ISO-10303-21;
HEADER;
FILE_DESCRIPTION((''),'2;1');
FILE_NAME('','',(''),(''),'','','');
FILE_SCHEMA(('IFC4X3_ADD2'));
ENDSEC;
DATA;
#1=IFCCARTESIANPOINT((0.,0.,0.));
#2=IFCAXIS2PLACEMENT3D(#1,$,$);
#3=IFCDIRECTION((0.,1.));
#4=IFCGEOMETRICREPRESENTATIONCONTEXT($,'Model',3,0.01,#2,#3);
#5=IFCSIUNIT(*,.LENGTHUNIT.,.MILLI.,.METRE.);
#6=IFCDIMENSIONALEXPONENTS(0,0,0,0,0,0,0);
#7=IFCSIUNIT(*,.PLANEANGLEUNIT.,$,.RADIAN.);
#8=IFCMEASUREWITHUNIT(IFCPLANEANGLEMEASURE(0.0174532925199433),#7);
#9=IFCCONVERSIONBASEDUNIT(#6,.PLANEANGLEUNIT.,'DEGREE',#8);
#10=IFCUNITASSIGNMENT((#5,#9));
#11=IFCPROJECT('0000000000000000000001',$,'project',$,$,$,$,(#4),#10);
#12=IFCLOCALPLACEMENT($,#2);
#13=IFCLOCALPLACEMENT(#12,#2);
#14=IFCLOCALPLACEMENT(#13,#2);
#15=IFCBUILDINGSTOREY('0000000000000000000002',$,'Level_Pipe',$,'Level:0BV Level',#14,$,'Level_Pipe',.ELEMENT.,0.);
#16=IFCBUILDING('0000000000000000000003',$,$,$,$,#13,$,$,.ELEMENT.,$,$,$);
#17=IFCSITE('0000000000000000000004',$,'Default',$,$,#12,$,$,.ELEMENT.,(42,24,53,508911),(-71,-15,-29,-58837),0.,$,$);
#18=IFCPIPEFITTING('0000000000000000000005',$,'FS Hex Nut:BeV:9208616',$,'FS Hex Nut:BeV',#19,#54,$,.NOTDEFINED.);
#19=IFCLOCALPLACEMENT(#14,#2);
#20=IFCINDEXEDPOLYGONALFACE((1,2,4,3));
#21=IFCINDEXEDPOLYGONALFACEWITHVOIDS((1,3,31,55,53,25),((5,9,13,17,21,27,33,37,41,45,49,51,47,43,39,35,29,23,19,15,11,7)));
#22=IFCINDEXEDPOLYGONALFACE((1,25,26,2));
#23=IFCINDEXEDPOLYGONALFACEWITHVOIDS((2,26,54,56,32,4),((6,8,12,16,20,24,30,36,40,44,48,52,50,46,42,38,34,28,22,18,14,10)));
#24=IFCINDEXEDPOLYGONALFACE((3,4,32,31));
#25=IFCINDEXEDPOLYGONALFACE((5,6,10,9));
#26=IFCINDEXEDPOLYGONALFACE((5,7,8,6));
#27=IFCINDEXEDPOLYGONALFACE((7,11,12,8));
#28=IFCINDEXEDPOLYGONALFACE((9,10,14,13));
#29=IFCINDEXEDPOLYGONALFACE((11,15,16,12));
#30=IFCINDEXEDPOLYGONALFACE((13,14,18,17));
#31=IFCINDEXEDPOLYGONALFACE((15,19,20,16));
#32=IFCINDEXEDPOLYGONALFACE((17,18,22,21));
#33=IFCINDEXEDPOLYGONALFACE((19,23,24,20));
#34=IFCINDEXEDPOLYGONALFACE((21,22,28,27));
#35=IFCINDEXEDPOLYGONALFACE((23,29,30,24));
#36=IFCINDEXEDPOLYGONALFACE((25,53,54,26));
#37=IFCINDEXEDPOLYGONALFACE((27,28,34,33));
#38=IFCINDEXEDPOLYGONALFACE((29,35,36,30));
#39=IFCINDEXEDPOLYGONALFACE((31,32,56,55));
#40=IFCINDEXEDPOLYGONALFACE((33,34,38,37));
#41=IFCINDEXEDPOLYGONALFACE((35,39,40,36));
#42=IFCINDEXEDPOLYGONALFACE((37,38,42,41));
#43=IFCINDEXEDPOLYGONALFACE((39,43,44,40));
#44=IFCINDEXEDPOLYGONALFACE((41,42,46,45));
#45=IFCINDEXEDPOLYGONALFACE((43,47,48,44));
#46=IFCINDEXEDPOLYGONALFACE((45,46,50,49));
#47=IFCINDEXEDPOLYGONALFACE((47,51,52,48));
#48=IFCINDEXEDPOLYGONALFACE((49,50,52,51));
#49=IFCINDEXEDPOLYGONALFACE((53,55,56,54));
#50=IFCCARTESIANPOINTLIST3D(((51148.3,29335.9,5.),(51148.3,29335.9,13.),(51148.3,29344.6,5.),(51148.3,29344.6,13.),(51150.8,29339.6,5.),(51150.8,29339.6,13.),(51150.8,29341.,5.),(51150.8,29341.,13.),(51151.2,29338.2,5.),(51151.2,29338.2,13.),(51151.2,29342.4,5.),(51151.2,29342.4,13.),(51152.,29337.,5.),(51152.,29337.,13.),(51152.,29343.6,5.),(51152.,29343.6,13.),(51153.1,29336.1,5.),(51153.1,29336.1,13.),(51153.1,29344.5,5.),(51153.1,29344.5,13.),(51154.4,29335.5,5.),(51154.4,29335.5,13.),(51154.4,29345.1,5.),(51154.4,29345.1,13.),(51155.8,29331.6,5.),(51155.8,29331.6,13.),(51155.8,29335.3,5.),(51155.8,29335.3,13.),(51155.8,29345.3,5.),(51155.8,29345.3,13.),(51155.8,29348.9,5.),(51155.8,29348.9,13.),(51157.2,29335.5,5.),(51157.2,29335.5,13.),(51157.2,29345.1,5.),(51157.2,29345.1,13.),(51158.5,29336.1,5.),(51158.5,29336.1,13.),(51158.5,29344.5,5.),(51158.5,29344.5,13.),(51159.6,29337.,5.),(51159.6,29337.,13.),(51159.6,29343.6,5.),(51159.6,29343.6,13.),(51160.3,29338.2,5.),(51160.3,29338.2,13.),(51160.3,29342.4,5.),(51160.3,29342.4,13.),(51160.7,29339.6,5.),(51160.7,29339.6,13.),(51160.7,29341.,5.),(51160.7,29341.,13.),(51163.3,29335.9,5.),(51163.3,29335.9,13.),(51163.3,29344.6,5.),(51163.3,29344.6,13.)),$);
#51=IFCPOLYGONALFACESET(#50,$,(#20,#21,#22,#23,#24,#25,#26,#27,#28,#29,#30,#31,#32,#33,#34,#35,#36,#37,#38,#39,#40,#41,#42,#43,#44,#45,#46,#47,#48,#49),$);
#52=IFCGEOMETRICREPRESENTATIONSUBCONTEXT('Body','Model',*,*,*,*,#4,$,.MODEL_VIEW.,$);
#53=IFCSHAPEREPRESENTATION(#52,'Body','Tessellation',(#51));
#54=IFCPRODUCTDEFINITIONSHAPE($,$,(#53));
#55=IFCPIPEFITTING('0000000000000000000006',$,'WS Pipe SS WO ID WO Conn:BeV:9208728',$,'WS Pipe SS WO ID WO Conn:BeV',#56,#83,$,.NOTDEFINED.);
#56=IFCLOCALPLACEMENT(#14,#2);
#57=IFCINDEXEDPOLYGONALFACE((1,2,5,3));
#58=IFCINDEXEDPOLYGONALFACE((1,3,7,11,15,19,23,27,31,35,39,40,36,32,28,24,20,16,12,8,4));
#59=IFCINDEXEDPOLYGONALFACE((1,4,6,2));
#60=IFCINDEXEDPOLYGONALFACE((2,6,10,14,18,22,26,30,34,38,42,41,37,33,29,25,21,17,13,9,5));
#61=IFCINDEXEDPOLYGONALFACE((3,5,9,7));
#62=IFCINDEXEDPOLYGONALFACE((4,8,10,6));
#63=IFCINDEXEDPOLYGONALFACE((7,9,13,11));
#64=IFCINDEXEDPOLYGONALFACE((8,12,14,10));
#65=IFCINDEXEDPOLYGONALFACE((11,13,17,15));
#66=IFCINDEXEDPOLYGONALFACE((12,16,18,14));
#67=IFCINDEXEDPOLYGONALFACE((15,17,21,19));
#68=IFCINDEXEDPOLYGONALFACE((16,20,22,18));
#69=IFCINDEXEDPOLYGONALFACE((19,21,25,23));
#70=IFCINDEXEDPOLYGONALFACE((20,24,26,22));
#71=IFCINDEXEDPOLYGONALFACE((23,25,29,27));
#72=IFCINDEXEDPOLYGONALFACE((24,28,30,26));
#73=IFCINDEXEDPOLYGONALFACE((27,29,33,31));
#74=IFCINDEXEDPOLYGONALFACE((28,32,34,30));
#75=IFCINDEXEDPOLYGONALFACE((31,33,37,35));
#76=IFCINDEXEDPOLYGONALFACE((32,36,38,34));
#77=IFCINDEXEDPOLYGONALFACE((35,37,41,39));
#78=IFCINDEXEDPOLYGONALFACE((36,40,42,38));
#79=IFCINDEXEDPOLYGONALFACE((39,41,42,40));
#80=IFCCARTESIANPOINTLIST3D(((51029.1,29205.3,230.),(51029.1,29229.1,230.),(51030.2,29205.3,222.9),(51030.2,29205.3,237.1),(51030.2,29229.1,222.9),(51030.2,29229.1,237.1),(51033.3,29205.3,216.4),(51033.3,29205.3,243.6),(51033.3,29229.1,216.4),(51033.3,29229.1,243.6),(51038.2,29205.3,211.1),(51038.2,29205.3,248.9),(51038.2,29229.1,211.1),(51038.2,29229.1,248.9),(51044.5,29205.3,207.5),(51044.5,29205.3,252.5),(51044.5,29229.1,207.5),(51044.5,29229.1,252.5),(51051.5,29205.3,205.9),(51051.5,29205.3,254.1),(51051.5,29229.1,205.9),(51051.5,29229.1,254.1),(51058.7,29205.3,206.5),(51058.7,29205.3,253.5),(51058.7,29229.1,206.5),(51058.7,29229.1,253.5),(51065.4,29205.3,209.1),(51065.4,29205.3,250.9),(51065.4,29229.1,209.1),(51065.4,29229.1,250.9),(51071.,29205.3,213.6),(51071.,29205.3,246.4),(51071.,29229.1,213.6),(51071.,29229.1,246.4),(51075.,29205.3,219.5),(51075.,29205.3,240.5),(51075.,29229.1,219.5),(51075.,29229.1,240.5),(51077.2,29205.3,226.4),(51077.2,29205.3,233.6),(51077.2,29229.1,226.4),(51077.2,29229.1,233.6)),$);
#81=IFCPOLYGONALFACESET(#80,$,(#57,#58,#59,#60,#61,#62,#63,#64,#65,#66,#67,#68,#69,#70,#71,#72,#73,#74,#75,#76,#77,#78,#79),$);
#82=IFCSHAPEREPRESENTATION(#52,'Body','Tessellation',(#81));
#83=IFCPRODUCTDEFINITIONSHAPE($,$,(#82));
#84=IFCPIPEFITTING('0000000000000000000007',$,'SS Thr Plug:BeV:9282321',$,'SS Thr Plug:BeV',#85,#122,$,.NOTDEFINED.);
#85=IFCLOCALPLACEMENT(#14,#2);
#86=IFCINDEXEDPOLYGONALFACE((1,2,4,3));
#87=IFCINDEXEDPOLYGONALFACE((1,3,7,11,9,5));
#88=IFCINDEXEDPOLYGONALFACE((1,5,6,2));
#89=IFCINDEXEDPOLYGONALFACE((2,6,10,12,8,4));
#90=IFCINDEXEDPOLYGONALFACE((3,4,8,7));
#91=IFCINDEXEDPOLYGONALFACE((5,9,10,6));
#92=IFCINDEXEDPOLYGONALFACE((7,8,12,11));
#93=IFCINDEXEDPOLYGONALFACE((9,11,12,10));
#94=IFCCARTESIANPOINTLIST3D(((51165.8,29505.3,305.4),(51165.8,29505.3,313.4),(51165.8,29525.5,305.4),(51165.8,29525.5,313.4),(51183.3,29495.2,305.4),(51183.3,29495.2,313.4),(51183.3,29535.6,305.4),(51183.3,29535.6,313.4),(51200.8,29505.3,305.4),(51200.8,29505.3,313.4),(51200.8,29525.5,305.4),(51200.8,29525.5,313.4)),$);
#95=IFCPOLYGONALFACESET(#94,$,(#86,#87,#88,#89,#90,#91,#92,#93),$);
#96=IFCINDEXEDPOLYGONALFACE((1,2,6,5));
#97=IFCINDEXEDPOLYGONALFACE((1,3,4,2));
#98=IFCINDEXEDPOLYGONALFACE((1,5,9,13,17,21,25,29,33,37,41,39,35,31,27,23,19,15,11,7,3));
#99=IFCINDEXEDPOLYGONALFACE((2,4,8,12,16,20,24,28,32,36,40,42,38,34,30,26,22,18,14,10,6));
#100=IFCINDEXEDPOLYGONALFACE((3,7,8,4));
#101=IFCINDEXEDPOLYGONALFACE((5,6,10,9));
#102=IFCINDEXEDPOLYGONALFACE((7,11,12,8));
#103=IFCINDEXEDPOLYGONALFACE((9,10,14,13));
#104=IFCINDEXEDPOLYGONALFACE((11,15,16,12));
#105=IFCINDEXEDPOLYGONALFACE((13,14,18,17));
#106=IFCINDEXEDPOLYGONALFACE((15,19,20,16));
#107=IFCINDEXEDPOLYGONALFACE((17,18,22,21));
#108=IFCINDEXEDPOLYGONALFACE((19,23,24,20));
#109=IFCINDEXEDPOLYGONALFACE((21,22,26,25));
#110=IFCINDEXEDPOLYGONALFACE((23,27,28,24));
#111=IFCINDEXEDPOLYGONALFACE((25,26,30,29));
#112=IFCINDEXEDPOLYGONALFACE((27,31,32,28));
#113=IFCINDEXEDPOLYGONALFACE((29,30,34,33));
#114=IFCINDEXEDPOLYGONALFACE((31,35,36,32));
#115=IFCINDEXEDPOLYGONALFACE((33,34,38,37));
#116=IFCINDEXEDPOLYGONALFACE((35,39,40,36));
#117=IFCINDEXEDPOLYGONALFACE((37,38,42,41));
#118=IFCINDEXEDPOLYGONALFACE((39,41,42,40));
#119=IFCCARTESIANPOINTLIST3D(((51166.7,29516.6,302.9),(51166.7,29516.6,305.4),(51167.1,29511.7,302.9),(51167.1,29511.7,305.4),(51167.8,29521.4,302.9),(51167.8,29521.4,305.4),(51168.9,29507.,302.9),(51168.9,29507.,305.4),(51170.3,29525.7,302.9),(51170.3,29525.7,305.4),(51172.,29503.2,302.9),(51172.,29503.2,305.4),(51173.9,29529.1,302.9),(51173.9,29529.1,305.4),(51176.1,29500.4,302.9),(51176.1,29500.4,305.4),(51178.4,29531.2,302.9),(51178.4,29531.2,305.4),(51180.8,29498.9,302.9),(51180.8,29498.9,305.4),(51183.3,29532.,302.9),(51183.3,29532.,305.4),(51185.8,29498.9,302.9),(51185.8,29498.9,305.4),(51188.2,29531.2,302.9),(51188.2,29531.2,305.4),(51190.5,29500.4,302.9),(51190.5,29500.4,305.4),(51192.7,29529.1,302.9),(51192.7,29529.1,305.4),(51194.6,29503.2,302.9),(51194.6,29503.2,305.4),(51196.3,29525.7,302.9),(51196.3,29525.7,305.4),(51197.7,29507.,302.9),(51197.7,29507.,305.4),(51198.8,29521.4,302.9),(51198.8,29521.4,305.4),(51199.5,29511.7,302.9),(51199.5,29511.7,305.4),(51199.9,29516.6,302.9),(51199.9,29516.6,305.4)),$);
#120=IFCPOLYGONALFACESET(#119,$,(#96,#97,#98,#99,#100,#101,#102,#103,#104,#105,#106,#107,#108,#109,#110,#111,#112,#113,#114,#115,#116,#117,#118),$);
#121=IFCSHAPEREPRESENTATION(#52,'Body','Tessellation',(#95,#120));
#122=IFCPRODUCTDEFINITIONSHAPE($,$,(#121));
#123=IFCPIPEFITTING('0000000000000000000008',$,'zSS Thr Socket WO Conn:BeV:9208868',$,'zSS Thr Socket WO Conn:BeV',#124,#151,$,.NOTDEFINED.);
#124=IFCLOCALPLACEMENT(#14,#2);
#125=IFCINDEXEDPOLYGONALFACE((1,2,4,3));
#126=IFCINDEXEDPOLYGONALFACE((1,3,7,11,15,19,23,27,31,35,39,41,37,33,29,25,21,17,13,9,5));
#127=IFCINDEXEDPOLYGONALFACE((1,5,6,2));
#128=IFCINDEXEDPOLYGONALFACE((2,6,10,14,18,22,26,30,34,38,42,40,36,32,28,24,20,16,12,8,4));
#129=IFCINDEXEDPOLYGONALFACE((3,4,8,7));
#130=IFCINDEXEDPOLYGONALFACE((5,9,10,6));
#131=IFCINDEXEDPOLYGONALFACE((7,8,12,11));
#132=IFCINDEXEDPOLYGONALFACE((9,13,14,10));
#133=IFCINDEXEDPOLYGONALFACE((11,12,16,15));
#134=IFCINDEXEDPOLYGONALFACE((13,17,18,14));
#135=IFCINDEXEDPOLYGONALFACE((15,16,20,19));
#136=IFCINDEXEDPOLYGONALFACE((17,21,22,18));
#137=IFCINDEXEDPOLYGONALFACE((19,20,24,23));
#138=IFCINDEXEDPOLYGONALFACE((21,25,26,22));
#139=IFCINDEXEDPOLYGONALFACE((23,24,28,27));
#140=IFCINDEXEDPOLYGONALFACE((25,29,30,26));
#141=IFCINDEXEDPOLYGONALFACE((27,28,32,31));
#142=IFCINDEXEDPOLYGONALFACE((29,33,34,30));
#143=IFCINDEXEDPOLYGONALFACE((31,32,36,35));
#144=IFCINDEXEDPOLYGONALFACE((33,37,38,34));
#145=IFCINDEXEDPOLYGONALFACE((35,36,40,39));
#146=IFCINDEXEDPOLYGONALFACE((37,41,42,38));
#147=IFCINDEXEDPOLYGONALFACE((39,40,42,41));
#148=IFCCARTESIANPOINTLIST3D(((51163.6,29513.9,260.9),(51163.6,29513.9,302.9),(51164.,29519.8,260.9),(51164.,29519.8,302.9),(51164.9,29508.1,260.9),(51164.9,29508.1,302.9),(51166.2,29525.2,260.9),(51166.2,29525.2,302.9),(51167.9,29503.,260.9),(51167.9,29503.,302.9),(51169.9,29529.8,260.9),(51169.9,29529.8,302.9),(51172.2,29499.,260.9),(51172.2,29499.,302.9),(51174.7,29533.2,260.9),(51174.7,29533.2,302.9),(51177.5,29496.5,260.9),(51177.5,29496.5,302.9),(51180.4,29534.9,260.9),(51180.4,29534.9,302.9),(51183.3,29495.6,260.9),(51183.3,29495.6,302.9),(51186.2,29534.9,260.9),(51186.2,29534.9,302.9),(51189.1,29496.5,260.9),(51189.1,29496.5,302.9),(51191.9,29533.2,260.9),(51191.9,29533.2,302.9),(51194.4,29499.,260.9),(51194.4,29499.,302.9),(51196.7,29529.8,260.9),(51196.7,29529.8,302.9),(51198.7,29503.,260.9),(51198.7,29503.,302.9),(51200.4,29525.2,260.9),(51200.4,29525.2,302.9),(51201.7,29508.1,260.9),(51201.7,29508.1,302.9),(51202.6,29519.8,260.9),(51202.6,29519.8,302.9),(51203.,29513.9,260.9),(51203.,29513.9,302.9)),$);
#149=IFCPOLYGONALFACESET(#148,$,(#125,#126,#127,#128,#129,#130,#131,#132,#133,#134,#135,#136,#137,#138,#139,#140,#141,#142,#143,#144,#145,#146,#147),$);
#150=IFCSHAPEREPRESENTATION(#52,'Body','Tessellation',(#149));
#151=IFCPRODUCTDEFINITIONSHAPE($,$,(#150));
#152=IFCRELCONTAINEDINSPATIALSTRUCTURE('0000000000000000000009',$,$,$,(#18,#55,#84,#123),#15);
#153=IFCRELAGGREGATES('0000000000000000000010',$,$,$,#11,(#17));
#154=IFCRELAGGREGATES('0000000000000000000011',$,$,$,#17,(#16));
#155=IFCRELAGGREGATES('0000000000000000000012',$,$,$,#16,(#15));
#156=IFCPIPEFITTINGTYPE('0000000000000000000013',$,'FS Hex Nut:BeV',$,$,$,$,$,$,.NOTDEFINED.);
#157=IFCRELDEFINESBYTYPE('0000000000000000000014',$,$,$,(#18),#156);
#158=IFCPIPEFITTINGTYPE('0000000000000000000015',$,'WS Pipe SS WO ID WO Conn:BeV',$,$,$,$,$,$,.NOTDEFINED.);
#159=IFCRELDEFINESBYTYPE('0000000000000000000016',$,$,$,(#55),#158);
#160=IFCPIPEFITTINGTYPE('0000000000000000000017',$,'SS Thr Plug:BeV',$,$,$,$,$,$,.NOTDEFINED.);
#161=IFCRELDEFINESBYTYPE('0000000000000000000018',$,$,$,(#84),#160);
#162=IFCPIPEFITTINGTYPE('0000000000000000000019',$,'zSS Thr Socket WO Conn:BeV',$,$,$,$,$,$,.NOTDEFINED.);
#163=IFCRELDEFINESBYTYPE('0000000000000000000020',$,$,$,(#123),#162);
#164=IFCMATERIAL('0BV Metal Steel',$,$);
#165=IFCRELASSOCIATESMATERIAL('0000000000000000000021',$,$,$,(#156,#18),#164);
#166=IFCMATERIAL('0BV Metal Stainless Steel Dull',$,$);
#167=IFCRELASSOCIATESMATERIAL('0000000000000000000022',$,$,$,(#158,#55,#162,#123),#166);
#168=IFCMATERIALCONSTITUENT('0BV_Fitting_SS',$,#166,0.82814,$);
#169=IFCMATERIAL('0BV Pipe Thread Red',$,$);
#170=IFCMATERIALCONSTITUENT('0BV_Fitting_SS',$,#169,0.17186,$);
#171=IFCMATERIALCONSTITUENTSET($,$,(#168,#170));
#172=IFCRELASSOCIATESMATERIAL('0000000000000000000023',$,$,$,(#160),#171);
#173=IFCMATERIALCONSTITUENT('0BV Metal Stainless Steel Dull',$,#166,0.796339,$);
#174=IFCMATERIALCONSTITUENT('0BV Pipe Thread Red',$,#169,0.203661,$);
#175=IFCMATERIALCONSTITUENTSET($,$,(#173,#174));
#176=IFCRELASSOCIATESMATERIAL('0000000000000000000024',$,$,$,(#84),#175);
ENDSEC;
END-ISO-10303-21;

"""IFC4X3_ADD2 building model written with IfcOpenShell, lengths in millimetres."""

from ifc_helpers import new_model, entity, si_unit, converted_unit, direction, frame, frame_2d, origin, place, context, subcontext, project, spatial, polyline, circle_curve, parameter, trimmed, segment, composite_curve, circle, outline, extrude, source, transform, mapped, material, constituent, constituent_set, type_object, type_shapes, element, save


model = new_model("IFC4X3_ADD2")

# Units and contexts
model_context = context("Model", 3, precision=0.01, world=origin(), true_north=direction((0.0, 1.0)))
body_context = subcontext(model_context, "Body", "Model", "MODEL_VIEW")
ifc_project = project(units=[si_unit("LENGTHUNIT", "METRE", prefix="MILLI"), converted_unit("PLANEANGLEUNIT", "DEGREE", entity("IfcPlaneAngleMeasure", 0.0174532925199433), si_unit("PLANEANGLEUNIT", "RADIAN"), dimensions=[0, 0, 0, 0, 0, 0, 0])], contexts=[model_context])

# Site, building, storey
site_placement = place(None, origin())
site = spatial("IfcSite", under=ifc_project, at=site_placement, Name="Default", CompositionType="ELEMENT", RefLatitude=(42, 24, 53, 508911), RefLongitude=(-71, -15, -29, -58837), RefElevation=0.0)
building_placement = place(site_placement, origin())
building = spatial("IfcBuilding", under=site, at=building_placement, CompositionType="ELEMENT")
storey_placement = place(building_placement, origin())
storey = spatial("IfcBuildingStorey", under=building, at=storey_placement, Name="Level_Pipe", ObjectType="Level:0BV Level", LongName="Level_Pipe", CompositionType="ELEMENT", Elevation=0.0)

# Pipe fittings
ifc_material_1 = material(Name="0BV Metal Stainless Steel Dull")
ifc_material_2 = material(Name="0BV Metal Steel")
ifc_material_3 = material(Name="0BV Pipe Thread Red")
pipe_fitting_type_1 = type_object("IfcPipeFittingType", Name="FS Hex Nut:BeV", PredefinedType="NOTDEFINED", material=ifc_material_2)
shared_shape_1 = source(origin(), body_context, "Body", "SweptSolid", [
    extrude(outline(polyline([(-4.3, -7.5), (4.3, -7.5), (8.7, 0.0), (4.3, 7.5), (-4.3, 7.5), (-8.7, 0.0), (-4.3, -7.5)]), holes=[composite_curve([segment(trimmed(circle_curve(frame_2d((0.0, 0.0), x_axis=(-0.5, 0.866025)), 5.0), [parameter(0.0)], [parameter(180.0)], True, "PARAMETER"), False, "CONTINUOUS"), segment(trimmed(circle_curve(frame_2d((0.0, 0.0), x_axis=(-0.5, 0.866025)), 5.0), [parameter(180.0)], [parameter(360.0)], True, "PARAMETER"), False, "CONTINUOUS")], self_intersect=False)]), frame((0.0, 8.7, 7.5), z_axis=(1.0, 0.0, 0.0), x_axis=(0.0, -0.5, -0.866025)), (0.0, 0.0, 1.0), 8.0),
])
type_shapes(pipe_fitting_type_1, [shared_shape_1])
pipe_fitting_1_placement = place(storey_placement, frame((51148.3, 29331.6, 13.0), z_axis=(1.0, 0.0, 0.0), x_axis=(0.0, 0.0, -1.0)))
element("IfcPipeFitting", 1, at=pipe_fitting_1_placement, inside=storey, type_object=pipe_fitting_type_1, material=ifc_material_2, Name="FS Hex Nut:BeV:9208616", ObjectType="FS Hex Nut:BeV", PredefinedType="NOTDEFINED", context=body_context, shape_type="MappedRepresentation", body=[
    mapped(shared_shape_1, transform((0.0, 0.0, 0.0), scale=1.0)),
])
pipe_fitting_type_2 = type_object("IfcPipeFittingType", Name="WS Pipe SS WO ID WO Conn:BeV", PredefinedType="NOTDEFINED", material=ifc_material_1)
shared_shape_2 = source(origin(), body_context, "Body", "SweptSolid", [
    extrude(circle(Radius=24.1, at=frame_2d((0.0, 0.0), x_axis=(1.0, 0.0))), frame((-11.9, 0.0, 0.0), z_axis=(1.0, 0.0, 0.0), x_axis=(0.0, 1.0, 0.0)), (0.0, 0.0, 1.0), 23.8),
])
type_shapes(pipe_fitting_type_2, [shared_shape_2])
pipe_fitting_2_placement = place(storey_placement, frame((51053.3, 29217.2, 230.0), z_axis=(0.0, 0.0, 1.0), x_axis=(0.0, 1.0, 0.0)))
element("IfcPipeFitting", 2, at=pipe_fitting_2_placement, inside=storey, type_object=pipe_fitting_type_2, material=ifc_material_1, Name="WS Pipe SS WO ID WO Conn:BeV:9208728", ObjectType="WS Pipe SS WO ID WO Conn:BeV", PredefinedType="NOTDEFINED", context=body_context, shape_type="MappedRepresentation", body=[
    mapped(shared_shape_2, transform((0.0, 0.0, 0.0), scale=1.0)),
])
ifc_constituent_1 = constituent(ifc_material_1, Name="0BV Metal Stainless Steel Dull", fraction=0.796339)
ifc_constituent_2 = constituent(ifc_material_3, Name="0BV Pipe Thread Red", fraction=0.203661)
ifc_constituent_set_1 = constituent_set(constituents=[ifc_constituent_1, ifc_constituent_2])
ifc_constituent_3 = constituent(ifc_material_1, Name="0BV_Fitting_SS", fraction=0.82814)
ifc_constituent_4 = constituent(ifc_material_3, Name="0BV_Fitting_SS", fraction=0.17186)
ifc_constituent_set_2 = constituent_set(constituents=[ifc_constituent_3, ifc_constituent_4])
pipe_fitting_type_3 = type_object("IfcPipeFittingType", Name="SS Thr Plug:BeV", PredefinedType="NOTDEFINED", material=ifc_constituent_set_2)
shared_shape_3 = source(origin(), body_context, "Body", "SweptSolid", [
    extrude(outline(polyline([(-10.1, -17.5), (10.1, -17.5), (20.2, 0.0), (10.1, 17.5), (-10.1, 17.5), (-20.2, 0.0), (-10.1, -17.5)])), frame((2.5, 0.0, 0.0), z_axis=(1.0, 0.0, 0.0), x_axis=(0.0, -0.5, -0.866025)), (0.0, 0.0, 1.0), 8.0),
    extrude(circle(Radius=16.6, at=frame_2d((0.0, 0.0), x_axis=(1.0, 0.0))), frame((0.0, 0.0, 0.0), z_axis=(1.0, 0.0, 0.0), x_axis=(0.0, 1.0, 0.0)), (0.0, 0.0, 1.0), 2.5),
])
type_shapes(pipe_fitting_type_3, [shared_shape_3])
pipe_fitting_3_placement = place(storey_placement, frame((51183.3, 29515.4, 302.9), z_axis=(-1.0, 0.0, 0.0), x_axis=(0.0, 0.0, 1.0)))
element("IfcPipeFitting", 3, at=pipe_fitting_3_placement, inside=storey, type_object=pipe_fitting_type_3, material=ifc_constituent_set_1, Name="SS Thr Plug:BeV:9282321", ObjectType="SS Thr Plug:BeV", PredefinedType="NOTDEFINED", context=body_context, shape_type="MappedRepresentation", body=[
    mapped(shared_shape_3, transform((0.0, 0.0, 0.0), scale=1.0)),
])
pipe_fitting_type_4 = type_object("IfcPipeFittingType", Name="zSS Thr Socket WO Conn:BeV", PredefinedType="NOTDEFINED", material=ifc_material_1)
shared_shape_4 = source(origin(), body_context, "Body", "SweptSolid", [
    extrude(circle(Radius=19.8, at=frame_2d((0.0, 0.0), x_axis=(1.0, 0.0))), frame((-21.0, 0.0, 0.0), z_axis=(1.0, 0.0, 0.0), x_axis=(0.0, 1.0, 0.0)), (0.0, 0.0, 1.0), 42.0),
])
type_shapes(pipe_fitting_type_4, [shared_shape_4])
pipe_fitting_4_placement = place(storey_placement, frame((51183.3, 29515.4, 281.9), z_axis=(-1.0, 0.0, 0.0), x_axis=(0.0, 0.0, -1.0)))
element("IfcPipeFitting", 4, at=pipe_fitting_4_placement, inside=storey, type_object=pipe_fitting_type_4, material=ifc_material_1, Name="zSS Thr Socket WO Conn:BeV:9208868", ObjectType="zSS Thr Socket WO Conn:BeV", PredefinedType="NOTDEFINED", context=body_context, shape_type="MappedRepresentation", body=[
    mapped(shared_shape_4, transform((0.0, 0.0, 0.0), scale=1.0)),
])

save(model, "model.ifc")
